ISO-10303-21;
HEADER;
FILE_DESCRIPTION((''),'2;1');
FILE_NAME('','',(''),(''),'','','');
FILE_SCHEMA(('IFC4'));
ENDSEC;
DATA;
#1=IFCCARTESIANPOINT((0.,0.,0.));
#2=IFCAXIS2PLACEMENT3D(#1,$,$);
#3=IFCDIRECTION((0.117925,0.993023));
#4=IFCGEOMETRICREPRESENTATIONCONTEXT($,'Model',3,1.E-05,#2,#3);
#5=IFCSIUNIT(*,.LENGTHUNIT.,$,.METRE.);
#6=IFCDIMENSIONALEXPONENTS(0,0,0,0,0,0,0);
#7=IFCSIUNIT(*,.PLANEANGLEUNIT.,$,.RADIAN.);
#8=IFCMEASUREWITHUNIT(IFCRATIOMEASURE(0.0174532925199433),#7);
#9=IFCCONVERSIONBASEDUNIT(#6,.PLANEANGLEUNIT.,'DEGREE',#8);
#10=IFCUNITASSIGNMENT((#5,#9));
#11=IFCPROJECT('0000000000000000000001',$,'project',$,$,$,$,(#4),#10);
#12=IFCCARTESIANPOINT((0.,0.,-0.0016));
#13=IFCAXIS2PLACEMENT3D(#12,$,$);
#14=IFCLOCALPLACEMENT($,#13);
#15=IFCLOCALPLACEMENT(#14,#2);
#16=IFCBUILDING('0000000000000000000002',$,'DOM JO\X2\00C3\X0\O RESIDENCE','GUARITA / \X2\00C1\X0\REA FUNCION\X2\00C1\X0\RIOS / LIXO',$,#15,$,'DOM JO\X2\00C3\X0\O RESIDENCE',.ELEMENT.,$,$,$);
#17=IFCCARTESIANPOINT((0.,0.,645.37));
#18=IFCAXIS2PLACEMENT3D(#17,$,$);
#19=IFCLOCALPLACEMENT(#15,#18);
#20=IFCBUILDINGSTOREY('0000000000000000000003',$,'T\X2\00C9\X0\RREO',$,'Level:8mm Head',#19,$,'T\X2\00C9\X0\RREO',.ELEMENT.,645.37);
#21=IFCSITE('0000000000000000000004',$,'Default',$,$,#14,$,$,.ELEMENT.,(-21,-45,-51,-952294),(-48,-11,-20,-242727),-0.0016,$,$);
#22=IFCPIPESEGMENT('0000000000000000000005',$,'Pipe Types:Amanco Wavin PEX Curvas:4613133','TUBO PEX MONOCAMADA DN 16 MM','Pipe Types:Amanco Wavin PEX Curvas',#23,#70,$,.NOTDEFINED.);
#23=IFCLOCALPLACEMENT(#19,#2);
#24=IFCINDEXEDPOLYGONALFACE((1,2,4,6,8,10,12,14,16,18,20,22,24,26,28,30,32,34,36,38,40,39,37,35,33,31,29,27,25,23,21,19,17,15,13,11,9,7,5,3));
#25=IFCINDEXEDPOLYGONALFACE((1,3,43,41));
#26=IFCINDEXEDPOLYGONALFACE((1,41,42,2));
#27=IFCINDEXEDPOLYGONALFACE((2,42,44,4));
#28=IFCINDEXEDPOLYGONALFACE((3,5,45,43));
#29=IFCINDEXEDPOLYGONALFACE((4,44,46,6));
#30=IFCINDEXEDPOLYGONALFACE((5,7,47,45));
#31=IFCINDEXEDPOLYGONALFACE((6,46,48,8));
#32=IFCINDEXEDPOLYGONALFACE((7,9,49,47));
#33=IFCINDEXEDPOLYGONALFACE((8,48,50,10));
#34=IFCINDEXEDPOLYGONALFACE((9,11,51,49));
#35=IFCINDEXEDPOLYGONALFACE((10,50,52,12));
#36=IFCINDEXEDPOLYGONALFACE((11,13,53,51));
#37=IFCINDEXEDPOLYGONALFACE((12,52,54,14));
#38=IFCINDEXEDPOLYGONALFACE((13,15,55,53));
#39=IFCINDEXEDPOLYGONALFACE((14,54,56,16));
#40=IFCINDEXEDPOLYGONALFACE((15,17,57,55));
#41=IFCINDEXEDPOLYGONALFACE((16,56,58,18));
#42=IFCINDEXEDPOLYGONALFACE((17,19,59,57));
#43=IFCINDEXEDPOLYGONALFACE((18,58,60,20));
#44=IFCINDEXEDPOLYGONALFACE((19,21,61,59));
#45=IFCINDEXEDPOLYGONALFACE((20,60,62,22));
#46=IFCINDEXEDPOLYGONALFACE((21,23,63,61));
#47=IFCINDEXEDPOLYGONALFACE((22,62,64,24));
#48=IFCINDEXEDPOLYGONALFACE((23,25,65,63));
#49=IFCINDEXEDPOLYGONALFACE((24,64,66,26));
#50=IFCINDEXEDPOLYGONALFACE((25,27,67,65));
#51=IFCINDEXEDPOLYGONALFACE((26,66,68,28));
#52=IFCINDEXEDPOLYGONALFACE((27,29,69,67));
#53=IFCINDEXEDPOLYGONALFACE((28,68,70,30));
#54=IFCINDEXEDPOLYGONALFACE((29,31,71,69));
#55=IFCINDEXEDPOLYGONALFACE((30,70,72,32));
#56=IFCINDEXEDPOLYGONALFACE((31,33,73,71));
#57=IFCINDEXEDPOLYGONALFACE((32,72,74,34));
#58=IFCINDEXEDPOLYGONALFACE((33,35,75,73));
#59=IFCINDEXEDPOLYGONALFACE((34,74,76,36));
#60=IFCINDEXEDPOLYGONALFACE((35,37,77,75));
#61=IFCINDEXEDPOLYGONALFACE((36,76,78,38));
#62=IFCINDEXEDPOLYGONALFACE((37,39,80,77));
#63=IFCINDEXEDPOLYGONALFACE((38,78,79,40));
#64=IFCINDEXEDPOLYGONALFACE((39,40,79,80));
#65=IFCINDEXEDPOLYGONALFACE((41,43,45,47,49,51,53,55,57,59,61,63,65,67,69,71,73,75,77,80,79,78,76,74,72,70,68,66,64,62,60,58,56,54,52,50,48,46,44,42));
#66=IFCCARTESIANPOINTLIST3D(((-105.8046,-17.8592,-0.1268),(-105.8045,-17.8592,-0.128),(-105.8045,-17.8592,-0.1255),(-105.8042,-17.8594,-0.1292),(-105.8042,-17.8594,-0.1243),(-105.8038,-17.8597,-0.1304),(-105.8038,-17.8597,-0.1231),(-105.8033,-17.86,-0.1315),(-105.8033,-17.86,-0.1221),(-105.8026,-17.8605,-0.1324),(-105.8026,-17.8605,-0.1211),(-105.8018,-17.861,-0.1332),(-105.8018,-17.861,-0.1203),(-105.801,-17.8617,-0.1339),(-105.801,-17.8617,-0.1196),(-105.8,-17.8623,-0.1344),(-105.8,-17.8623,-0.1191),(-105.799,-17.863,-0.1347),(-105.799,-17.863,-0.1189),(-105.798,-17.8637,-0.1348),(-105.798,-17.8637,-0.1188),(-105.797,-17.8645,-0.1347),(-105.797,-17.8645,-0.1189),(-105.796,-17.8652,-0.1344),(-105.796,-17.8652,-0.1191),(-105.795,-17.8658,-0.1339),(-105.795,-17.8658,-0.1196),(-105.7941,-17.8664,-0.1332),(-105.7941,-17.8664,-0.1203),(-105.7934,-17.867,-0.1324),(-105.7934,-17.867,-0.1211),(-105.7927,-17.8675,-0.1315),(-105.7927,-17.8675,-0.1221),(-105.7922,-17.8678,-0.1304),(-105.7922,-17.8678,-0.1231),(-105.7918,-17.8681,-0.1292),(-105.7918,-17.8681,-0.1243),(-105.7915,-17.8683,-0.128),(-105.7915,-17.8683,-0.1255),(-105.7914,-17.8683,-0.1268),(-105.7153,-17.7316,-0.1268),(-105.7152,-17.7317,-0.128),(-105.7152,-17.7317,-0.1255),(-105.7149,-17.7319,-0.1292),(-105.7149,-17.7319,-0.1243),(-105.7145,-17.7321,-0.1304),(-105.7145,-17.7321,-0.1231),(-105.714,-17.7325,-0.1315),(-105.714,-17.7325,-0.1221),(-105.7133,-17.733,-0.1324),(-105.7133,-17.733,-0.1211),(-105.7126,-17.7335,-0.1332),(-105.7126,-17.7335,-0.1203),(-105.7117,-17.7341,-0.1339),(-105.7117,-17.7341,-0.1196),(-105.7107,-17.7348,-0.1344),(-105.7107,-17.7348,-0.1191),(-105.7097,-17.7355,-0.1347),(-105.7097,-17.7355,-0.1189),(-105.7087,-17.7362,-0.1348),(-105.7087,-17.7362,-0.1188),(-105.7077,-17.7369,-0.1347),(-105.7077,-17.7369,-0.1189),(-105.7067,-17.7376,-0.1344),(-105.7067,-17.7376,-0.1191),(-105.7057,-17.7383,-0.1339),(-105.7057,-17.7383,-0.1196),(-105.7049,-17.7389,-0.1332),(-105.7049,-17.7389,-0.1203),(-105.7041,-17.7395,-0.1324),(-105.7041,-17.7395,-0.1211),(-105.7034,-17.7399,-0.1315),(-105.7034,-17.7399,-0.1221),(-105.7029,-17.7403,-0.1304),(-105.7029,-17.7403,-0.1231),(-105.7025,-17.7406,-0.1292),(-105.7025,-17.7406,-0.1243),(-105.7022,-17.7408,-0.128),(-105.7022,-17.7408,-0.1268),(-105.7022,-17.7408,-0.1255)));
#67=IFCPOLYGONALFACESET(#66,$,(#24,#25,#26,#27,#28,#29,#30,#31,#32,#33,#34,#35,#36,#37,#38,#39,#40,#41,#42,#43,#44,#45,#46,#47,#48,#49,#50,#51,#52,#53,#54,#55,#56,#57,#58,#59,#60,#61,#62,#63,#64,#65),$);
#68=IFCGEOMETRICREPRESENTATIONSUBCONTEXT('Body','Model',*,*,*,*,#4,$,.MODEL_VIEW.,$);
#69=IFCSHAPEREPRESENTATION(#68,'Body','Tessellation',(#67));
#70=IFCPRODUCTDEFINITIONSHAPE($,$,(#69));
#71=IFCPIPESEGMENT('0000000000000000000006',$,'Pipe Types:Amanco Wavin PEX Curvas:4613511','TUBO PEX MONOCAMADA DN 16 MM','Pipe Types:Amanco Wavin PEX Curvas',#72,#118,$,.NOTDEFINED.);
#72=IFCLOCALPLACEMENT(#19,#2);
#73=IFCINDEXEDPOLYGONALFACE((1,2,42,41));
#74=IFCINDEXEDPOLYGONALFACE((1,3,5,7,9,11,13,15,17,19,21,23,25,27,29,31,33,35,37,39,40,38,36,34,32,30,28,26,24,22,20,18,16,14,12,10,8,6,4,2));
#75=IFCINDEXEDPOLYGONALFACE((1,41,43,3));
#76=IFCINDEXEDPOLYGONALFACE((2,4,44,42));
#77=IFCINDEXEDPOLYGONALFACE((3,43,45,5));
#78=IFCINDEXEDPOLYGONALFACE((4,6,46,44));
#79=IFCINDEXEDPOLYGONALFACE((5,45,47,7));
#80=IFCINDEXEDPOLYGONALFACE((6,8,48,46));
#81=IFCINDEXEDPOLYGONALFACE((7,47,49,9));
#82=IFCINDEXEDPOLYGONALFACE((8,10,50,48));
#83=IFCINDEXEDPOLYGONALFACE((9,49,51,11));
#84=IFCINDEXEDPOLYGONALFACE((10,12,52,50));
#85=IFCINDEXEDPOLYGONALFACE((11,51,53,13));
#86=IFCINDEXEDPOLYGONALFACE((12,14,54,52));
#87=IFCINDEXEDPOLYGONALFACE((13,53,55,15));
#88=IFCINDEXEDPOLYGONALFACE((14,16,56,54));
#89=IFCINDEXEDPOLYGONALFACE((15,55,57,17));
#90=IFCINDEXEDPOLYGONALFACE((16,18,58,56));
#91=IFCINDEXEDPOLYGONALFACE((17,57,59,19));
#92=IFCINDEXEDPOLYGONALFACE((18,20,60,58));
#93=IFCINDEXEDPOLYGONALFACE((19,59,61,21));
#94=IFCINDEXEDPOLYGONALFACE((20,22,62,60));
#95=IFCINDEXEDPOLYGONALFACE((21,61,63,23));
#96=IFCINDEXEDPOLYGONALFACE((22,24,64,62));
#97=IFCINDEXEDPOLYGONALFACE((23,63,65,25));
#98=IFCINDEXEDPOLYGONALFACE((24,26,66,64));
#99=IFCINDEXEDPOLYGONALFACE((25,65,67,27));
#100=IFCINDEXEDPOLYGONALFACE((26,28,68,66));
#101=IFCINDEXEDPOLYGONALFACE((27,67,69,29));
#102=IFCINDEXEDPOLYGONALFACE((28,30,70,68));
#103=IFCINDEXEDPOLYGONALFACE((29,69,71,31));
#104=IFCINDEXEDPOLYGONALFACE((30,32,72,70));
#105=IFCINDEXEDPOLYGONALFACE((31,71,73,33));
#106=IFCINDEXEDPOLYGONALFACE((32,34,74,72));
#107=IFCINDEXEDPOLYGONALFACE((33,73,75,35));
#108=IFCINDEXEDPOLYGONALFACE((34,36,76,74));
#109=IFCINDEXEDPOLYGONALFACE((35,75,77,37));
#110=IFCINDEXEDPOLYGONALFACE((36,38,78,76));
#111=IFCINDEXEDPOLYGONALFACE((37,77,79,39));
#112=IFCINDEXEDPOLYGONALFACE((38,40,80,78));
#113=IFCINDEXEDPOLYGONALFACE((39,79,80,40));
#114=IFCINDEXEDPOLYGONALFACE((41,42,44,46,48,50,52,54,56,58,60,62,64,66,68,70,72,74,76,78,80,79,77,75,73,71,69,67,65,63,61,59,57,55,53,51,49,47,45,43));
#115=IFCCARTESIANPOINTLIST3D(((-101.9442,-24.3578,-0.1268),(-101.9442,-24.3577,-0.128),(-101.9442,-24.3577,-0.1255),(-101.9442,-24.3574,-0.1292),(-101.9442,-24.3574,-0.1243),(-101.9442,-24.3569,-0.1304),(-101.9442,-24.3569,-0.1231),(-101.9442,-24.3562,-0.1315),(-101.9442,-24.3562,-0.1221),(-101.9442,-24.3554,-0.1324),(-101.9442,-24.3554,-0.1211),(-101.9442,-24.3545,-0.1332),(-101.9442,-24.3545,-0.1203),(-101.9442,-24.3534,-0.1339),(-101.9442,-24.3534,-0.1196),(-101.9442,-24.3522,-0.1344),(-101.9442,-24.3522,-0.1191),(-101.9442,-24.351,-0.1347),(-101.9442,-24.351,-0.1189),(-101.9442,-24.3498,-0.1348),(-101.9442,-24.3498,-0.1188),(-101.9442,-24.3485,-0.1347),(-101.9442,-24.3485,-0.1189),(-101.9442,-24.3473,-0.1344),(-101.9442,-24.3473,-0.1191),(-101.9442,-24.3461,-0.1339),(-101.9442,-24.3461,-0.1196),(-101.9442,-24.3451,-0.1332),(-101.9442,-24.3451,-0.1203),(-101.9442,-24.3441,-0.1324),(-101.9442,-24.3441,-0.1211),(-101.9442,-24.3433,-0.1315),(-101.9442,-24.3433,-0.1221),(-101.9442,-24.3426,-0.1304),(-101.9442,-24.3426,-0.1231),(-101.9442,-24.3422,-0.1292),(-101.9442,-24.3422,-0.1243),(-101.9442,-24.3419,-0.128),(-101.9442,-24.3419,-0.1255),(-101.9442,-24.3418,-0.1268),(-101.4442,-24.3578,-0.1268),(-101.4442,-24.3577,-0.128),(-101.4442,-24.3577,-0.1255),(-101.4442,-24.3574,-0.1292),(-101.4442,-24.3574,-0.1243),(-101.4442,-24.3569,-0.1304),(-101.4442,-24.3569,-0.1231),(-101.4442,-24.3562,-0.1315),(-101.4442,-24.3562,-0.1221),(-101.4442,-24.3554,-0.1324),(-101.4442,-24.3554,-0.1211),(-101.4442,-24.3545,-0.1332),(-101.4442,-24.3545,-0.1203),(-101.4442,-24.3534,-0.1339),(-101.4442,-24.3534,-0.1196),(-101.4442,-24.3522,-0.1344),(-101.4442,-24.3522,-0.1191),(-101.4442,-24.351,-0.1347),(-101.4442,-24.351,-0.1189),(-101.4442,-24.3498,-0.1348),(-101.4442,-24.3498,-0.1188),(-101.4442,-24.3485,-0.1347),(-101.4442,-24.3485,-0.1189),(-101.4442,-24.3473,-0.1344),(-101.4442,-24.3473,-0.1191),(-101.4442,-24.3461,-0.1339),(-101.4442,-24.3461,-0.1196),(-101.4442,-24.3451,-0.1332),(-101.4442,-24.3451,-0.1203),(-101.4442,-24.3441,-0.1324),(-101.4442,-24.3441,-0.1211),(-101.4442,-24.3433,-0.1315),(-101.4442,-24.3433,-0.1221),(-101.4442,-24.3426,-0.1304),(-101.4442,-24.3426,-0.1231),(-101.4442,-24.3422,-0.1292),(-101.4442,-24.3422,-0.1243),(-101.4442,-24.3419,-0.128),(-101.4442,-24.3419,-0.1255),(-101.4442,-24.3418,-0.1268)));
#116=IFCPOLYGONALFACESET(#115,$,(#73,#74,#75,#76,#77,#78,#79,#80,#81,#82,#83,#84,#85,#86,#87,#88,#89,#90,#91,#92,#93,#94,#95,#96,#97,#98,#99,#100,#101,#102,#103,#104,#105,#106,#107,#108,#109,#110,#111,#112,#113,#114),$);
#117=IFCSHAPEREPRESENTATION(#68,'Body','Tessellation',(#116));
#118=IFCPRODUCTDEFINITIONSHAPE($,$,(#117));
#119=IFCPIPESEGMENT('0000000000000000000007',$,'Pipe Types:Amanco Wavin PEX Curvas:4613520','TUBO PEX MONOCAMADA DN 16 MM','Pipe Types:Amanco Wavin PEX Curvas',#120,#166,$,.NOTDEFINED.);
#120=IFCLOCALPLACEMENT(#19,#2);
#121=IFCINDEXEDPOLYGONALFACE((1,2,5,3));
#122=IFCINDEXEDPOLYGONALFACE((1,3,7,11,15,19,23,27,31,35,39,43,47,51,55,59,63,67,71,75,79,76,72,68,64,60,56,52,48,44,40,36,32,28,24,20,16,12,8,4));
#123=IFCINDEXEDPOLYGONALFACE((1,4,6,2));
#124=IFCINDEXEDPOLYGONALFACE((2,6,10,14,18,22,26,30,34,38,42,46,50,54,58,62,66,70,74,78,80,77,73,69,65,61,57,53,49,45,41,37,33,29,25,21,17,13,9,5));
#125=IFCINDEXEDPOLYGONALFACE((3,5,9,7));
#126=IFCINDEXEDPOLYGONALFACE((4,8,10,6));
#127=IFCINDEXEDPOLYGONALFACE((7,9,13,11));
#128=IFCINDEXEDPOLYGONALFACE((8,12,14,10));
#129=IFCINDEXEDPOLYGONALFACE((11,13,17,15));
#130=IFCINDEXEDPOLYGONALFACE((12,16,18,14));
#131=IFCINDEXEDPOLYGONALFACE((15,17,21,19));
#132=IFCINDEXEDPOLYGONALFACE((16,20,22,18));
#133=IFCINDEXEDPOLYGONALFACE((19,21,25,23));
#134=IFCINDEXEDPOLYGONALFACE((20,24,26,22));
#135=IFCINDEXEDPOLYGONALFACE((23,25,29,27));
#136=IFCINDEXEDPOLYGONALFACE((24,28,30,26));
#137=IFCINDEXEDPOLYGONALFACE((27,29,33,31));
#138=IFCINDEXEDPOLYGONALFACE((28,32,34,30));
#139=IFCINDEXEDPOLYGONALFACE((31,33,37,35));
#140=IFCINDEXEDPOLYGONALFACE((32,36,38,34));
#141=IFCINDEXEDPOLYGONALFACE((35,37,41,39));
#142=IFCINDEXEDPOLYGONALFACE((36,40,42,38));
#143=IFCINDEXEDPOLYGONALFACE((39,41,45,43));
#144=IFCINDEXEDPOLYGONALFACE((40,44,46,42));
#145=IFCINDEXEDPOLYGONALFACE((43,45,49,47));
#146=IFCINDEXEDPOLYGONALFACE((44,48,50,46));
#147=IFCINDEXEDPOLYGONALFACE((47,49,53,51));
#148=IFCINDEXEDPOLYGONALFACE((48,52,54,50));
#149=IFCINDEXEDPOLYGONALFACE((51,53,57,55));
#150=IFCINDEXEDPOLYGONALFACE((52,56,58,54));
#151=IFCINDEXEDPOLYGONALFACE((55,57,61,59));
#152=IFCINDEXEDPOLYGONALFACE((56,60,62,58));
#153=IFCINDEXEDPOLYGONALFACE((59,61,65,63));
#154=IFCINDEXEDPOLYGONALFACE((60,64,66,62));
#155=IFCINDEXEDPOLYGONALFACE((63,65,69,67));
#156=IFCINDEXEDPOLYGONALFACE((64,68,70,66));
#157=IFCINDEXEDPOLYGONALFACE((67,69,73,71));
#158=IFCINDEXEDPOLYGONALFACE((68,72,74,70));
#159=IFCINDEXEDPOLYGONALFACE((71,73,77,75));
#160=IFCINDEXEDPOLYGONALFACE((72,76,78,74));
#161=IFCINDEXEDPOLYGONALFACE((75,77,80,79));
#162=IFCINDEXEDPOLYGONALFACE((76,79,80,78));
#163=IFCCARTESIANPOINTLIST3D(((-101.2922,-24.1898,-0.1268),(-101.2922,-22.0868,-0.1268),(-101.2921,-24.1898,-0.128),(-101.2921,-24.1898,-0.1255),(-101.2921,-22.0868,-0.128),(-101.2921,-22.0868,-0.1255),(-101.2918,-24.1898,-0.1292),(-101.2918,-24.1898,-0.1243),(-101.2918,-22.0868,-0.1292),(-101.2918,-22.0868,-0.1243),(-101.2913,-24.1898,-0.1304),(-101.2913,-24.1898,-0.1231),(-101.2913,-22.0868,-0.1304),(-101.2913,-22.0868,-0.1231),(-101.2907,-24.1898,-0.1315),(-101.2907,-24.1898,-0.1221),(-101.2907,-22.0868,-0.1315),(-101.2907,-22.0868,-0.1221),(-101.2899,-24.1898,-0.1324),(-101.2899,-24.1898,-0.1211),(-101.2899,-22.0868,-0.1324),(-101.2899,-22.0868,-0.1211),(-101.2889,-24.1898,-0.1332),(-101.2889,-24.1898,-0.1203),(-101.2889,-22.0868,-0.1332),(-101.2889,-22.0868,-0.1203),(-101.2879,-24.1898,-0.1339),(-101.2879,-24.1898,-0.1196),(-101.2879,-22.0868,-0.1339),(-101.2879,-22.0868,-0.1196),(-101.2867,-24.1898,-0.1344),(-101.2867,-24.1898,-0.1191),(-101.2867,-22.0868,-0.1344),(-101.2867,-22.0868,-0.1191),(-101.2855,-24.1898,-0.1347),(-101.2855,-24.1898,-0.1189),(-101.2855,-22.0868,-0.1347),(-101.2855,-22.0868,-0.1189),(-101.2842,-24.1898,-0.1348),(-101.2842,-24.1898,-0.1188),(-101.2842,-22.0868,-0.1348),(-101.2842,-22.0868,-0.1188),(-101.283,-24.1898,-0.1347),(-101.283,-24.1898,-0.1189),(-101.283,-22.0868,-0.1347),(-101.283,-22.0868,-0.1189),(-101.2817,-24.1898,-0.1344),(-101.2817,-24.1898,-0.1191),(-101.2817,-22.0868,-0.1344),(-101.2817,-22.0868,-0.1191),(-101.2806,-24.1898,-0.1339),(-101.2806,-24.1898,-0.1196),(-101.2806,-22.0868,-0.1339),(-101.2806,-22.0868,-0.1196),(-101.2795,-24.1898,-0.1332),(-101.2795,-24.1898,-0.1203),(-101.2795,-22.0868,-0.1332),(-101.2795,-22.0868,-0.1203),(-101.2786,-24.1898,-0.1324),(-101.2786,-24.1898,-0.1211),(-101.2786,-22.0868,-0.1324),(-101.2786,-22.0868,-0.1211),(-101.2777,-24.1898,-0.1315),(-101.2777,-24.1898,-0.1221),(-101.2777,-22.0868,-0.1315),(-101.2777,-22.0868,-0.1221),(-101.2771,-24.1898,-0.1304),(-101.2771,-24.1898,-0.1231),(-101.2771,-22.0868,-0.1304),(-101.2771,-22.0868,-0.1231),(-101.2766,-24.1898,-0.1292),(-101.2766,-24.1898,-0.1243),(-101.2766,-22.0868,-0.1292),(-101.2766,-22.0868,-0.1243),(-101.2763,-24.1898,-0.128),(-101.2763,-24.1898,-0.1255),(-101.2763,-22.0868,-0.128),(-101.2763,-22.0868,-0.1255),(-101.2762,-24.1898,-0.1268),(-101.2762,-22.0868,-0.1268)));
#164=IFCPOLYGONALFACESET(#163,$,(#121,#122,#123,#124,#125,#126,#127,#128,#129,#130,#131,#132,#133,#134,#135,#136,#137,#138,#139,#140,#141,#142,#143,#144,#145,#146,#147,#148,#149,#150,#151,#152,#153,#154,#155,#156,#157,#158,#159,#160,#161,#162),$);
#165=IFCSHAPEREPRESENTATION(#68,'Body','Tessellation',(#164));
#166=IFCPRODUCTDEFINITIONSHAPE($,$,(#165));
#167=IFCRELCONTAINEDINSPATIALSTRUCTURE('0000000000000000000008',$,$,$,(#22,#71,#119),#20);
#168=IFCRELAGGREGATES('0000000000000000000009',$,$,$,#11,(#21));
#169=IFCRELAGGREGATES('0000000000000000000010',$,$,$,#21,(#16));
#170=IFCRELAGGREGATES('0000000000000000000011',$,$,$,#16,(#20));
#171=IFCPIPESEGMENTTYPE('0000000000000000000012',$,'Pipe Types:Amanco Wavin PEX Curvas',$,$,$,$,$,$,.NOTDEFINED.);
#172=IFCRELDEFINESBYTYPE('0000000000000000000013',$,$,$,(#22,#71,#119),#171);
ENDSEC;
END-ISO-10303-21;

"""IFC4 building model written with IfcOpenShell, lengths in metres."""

from ifc_helpers import new_model, entity, si_unit, converted_unit, direction, frame, origin, place, context, subcontext, project, spatial, indexed_curve, outline, extrude, type_object, element, save


model = new_model("IFC4")

# Units and contexts
model_context = context("Model", 3, precision=1e-05, world=origin(), true_north=direction((0.117925, 0.993023)))
body_context = subcontext(model_context, "Body", "Model", "MODEL_VIEW")
ifc_project = project(units=[si_unit("LENGTHUNIT", "METRE"), converted_unit("PLANEANGLEUNIT", "DEGREE", entity("IfcRatioMeasure", 0.0174532925199433), si_unit("PLANEANGLEUNIT", "RADIAN"), dimensions=[0, 0, 0, 0, 0, 0, 0])], contexts=[model_context])

# Site, building, storey
site_placement = place(None, frame((0.0, 0.0, -0.0016)))
site = spatial("IfcSite", under=ifc_project, at=site_placement, Name="Default", CompositionType="ELEMENT", RefLatitude=(-21, -45, -51, -952294), RefLongitude=(-48, -11, -20, -242727), RefElevation=-0.0016)
building_placement = place(site_placement, origin())
building = spatial("IfcBuilding", under=site, at=building_placement, Name="DOM JOÃO RESIDENCE", Description="GUARITA / ÁREA FUNCIONÁRIOS / LIXO", LongName="DOM JOÃO RESIDENCE", CompositionType="ELEMENT")
storey_placement = place(building_placement, frame((0.0, 0.0, 645.37)))
storey = spatial("IfcBuildingStorey", under=building, at=storey_placement, Name="TÉRREO", ObjectType="Level:8mm Head", LongName="TÉRREO", CompositionType="ELEMENT", Elevation=645.37)

# Pipe segments
pipe_segment_type_1 = type_object("IfcPipeSegmentType", Name="Pipe Types:Amanco Wavin PEX Curvas", PredefinedType="NOTDEFINED")
pipe_segment_1_placement = place(storey_placement, frame((-105.8061, -17.8699, -0.1364)))
element("IfcPipeSegment", 1, at=pipe_segment_1_placement, inside=storey, type_object=pipe_segment_type_1, Name="Pipe Types:Amanco Wavin PEX Curvas:4613133", Description="TUBO PEX MONOCAMADA DN 16 MM", ObjectType="Pipe Types:Amanco Wavin PEX Curvas", PredefinedType="NOTDEFINED", context=body_context, shape_type="SweptSolid", body=[
    extrude(outline(indexed_curve([(0.008, 0.0), (0.0079, 0.0013), (0.0076, 0.0025), (0.0071, 0.0036), (0.0065, 0.0047), (0.0057, 0.0057), (0.0047, 0.0065), (0.0036, 0.0071), (0.0025, 0.0076), (0.0013, 0.0079), (0.0, 0.008), (-0.0013, 0.0079), (-0.0025, 0.0076), (-0.0036, 0.0071), (-0.0047, 0.0065), (-0.0057, 0.0057), (-0.0065, 0.0047), (-0.0071, 0.0036), (-0.0076, 0.0025), (-0.0079, 0.0013), (-0.008, 0.0), (-0.0079, -0.0013), (-0.0076, -0.0025), (-0.0071, -0.0036), (-0.0065, -0.0047), (-0.0057, -0.0057), (-0.0047, -0.0065), (-0.0036, -0.0071), (-0.0025, -0.0076), (-0.0013, -0.0079), (0.0, -0.008), (0.0013, -0.0079), (0.0025, -0.0076), (0.0036, -0.0071), (0.0047, -0.0065), (0.0057, -0.0057), (0.0065, -0.0047), (0.0071, -0.0036), (0.0076, -0.0025), (0.0079, -0.0013), (0.008, 0.0)], self_intersect=False)), frame((0.0081, 0.0062, 0.0096), z_axis=(0.573576, 0.819152, 0.0), x_axis=(0.819152, -0.573576, 0.0)), (0.0, 0.0, 1.0), 0.1557),
])
pipe_segment_2_placement = place(storey_placement, frame((-101.9442, -24.3594, -0.1364)))
element("IfcPipeSegment", 2, at=pipe_segment_2_placement, inside=storey, type_object=pipe_segment_type_1, Name="Pipe Types:Amanco Wavin PEX Curvas:4613511", Description="TUBO PEX MONOCAMADA DN 16 MM", ObjectType="Pipe Types:Amanco Wavin PEX Curvas", PredefinedType="NOTDEFINED", context=body_context, shape_type="SweptSolid", body=[
    extrude(outline(indexed_curve([(0.008, 0.0), (0.0079, 0.0013), (0.0076, 0.0025), (0.0071, 0.0036), (0.0065, 0.0047), (0.0057, 0.0057), (0.0047, 0.0065), (0.0036, 0.0071), (0.0025, 0.0076), (0.0013, 0.0079), (0.0, 0.008), (-0.0013, 0.0079), (-0.0025, 0.0076), (-0.0036, 0.0071), (-0.0047, 0.0065), (-0.0057, 0.0057), (-0.0065, 0.0047), (-0.0071, 0.0036), (-0.0076, 0.0025), (-0.0079, 0.0013), (-0.008, 0.0), (-0.0079, -0.0013), (-0.0076, -0.0025), (-0.0071, -0.0036), (-0.0065, -0.0047), (-0.0057, -0.0057), (-0.0047, -0.0065), (-0.0036, -0.0071), (-0.0025, -0.0076), (-0.0013, -0.0079), (0.0, -0.008), (0.0013, -0.0079), (0.0025, -0.0076), (0.0036, -0.0071), (0.0047, -0.0065), (0.0057, -0.0057), (0.0065, -0.0047), (0.0071, -0.0036), (0.0076, -0.0025), (0.0079, -0.0013), (0.008, 0.0)], self_intersect=False)), frame((0.0, 0.0096, 0.0096), z_axis=(1.0, 0.0, 0.0), x_axis=(0.0, 1.0, 0.0)), (0.0, 0.0, 1.0), 0.5),
])
pipe_segment_3_placement = place(storey_placement, frame((-101.2938, -24.1898, -0.1364)))
element("IfcPipeSegment", 3, at=pipe_segment_3_placement, inside=storey, type_object=pipe_segment_type_1, Name="Pipe Types:Amanco Wavin PEX Curvas:4613520", Description="TUBO PEX MONOCAMADA DN 16 MM", ObjectType="Pipe Types:Amanco Wavin PEX Curvas", PredefinedType="NOTDEFINED", context=body_context, shape_type="SweptSolid", body=[
    extrude(outline(indexed_curve([(0.008, 0.0), (0.0079, 0.0013), (0.0076, 0.0025), (0.0071, 0.0036), (0.0065, 0.0047), (0.0057, 0.0057), (0.0047, 0.0065), (0.0036, 0.0071), (0.0025, 0.0076), (0.0013, 0.0079), (0.0, 0.008), (-0.0013, 0.0079), (-0.0025, 0.0076), (-0.0036, 0.0071), (-0.0047, 0.0065), (-0.0057, 0.0057), (-0.0065, 0.0047), (-0.0071, 0.0036), (-0.0076, 0.0025), (-0.0079, 0.0013), (-0.008, 0.0), (-0.0079, -0.0013), (-0.0076, -0.0025), (-0.0071, -0.0036), (-0.0065, -0.0047), (-0.0057, -0.0057), (-0.0047, -0.0065), (-0.0036, -0.0071), (-0.0025, -0.0076), (-0.0013, -0.0079), (0.0, -0.008), (0.0013, -0.0079), (0.0025, -0.0076), (0.0036, -0.0071), (0.0047, -0.0065), (0.0057, -0.0057), (0.0065, -0.0047), (0.0071, -0.0036), (0.0076, -0.0025), (0.0079, -0.0013), (0.008, 0.0)], self_intersect=False)), frame((0.0096, 0.0, 0.0096), z_axis=(0.0, 1.0, 0.0), x_axis=(-1.0, 0.0, 0.0)), (0.0, 0.0, 1.0), 2.103),
])

save(model, "model.ifc")
